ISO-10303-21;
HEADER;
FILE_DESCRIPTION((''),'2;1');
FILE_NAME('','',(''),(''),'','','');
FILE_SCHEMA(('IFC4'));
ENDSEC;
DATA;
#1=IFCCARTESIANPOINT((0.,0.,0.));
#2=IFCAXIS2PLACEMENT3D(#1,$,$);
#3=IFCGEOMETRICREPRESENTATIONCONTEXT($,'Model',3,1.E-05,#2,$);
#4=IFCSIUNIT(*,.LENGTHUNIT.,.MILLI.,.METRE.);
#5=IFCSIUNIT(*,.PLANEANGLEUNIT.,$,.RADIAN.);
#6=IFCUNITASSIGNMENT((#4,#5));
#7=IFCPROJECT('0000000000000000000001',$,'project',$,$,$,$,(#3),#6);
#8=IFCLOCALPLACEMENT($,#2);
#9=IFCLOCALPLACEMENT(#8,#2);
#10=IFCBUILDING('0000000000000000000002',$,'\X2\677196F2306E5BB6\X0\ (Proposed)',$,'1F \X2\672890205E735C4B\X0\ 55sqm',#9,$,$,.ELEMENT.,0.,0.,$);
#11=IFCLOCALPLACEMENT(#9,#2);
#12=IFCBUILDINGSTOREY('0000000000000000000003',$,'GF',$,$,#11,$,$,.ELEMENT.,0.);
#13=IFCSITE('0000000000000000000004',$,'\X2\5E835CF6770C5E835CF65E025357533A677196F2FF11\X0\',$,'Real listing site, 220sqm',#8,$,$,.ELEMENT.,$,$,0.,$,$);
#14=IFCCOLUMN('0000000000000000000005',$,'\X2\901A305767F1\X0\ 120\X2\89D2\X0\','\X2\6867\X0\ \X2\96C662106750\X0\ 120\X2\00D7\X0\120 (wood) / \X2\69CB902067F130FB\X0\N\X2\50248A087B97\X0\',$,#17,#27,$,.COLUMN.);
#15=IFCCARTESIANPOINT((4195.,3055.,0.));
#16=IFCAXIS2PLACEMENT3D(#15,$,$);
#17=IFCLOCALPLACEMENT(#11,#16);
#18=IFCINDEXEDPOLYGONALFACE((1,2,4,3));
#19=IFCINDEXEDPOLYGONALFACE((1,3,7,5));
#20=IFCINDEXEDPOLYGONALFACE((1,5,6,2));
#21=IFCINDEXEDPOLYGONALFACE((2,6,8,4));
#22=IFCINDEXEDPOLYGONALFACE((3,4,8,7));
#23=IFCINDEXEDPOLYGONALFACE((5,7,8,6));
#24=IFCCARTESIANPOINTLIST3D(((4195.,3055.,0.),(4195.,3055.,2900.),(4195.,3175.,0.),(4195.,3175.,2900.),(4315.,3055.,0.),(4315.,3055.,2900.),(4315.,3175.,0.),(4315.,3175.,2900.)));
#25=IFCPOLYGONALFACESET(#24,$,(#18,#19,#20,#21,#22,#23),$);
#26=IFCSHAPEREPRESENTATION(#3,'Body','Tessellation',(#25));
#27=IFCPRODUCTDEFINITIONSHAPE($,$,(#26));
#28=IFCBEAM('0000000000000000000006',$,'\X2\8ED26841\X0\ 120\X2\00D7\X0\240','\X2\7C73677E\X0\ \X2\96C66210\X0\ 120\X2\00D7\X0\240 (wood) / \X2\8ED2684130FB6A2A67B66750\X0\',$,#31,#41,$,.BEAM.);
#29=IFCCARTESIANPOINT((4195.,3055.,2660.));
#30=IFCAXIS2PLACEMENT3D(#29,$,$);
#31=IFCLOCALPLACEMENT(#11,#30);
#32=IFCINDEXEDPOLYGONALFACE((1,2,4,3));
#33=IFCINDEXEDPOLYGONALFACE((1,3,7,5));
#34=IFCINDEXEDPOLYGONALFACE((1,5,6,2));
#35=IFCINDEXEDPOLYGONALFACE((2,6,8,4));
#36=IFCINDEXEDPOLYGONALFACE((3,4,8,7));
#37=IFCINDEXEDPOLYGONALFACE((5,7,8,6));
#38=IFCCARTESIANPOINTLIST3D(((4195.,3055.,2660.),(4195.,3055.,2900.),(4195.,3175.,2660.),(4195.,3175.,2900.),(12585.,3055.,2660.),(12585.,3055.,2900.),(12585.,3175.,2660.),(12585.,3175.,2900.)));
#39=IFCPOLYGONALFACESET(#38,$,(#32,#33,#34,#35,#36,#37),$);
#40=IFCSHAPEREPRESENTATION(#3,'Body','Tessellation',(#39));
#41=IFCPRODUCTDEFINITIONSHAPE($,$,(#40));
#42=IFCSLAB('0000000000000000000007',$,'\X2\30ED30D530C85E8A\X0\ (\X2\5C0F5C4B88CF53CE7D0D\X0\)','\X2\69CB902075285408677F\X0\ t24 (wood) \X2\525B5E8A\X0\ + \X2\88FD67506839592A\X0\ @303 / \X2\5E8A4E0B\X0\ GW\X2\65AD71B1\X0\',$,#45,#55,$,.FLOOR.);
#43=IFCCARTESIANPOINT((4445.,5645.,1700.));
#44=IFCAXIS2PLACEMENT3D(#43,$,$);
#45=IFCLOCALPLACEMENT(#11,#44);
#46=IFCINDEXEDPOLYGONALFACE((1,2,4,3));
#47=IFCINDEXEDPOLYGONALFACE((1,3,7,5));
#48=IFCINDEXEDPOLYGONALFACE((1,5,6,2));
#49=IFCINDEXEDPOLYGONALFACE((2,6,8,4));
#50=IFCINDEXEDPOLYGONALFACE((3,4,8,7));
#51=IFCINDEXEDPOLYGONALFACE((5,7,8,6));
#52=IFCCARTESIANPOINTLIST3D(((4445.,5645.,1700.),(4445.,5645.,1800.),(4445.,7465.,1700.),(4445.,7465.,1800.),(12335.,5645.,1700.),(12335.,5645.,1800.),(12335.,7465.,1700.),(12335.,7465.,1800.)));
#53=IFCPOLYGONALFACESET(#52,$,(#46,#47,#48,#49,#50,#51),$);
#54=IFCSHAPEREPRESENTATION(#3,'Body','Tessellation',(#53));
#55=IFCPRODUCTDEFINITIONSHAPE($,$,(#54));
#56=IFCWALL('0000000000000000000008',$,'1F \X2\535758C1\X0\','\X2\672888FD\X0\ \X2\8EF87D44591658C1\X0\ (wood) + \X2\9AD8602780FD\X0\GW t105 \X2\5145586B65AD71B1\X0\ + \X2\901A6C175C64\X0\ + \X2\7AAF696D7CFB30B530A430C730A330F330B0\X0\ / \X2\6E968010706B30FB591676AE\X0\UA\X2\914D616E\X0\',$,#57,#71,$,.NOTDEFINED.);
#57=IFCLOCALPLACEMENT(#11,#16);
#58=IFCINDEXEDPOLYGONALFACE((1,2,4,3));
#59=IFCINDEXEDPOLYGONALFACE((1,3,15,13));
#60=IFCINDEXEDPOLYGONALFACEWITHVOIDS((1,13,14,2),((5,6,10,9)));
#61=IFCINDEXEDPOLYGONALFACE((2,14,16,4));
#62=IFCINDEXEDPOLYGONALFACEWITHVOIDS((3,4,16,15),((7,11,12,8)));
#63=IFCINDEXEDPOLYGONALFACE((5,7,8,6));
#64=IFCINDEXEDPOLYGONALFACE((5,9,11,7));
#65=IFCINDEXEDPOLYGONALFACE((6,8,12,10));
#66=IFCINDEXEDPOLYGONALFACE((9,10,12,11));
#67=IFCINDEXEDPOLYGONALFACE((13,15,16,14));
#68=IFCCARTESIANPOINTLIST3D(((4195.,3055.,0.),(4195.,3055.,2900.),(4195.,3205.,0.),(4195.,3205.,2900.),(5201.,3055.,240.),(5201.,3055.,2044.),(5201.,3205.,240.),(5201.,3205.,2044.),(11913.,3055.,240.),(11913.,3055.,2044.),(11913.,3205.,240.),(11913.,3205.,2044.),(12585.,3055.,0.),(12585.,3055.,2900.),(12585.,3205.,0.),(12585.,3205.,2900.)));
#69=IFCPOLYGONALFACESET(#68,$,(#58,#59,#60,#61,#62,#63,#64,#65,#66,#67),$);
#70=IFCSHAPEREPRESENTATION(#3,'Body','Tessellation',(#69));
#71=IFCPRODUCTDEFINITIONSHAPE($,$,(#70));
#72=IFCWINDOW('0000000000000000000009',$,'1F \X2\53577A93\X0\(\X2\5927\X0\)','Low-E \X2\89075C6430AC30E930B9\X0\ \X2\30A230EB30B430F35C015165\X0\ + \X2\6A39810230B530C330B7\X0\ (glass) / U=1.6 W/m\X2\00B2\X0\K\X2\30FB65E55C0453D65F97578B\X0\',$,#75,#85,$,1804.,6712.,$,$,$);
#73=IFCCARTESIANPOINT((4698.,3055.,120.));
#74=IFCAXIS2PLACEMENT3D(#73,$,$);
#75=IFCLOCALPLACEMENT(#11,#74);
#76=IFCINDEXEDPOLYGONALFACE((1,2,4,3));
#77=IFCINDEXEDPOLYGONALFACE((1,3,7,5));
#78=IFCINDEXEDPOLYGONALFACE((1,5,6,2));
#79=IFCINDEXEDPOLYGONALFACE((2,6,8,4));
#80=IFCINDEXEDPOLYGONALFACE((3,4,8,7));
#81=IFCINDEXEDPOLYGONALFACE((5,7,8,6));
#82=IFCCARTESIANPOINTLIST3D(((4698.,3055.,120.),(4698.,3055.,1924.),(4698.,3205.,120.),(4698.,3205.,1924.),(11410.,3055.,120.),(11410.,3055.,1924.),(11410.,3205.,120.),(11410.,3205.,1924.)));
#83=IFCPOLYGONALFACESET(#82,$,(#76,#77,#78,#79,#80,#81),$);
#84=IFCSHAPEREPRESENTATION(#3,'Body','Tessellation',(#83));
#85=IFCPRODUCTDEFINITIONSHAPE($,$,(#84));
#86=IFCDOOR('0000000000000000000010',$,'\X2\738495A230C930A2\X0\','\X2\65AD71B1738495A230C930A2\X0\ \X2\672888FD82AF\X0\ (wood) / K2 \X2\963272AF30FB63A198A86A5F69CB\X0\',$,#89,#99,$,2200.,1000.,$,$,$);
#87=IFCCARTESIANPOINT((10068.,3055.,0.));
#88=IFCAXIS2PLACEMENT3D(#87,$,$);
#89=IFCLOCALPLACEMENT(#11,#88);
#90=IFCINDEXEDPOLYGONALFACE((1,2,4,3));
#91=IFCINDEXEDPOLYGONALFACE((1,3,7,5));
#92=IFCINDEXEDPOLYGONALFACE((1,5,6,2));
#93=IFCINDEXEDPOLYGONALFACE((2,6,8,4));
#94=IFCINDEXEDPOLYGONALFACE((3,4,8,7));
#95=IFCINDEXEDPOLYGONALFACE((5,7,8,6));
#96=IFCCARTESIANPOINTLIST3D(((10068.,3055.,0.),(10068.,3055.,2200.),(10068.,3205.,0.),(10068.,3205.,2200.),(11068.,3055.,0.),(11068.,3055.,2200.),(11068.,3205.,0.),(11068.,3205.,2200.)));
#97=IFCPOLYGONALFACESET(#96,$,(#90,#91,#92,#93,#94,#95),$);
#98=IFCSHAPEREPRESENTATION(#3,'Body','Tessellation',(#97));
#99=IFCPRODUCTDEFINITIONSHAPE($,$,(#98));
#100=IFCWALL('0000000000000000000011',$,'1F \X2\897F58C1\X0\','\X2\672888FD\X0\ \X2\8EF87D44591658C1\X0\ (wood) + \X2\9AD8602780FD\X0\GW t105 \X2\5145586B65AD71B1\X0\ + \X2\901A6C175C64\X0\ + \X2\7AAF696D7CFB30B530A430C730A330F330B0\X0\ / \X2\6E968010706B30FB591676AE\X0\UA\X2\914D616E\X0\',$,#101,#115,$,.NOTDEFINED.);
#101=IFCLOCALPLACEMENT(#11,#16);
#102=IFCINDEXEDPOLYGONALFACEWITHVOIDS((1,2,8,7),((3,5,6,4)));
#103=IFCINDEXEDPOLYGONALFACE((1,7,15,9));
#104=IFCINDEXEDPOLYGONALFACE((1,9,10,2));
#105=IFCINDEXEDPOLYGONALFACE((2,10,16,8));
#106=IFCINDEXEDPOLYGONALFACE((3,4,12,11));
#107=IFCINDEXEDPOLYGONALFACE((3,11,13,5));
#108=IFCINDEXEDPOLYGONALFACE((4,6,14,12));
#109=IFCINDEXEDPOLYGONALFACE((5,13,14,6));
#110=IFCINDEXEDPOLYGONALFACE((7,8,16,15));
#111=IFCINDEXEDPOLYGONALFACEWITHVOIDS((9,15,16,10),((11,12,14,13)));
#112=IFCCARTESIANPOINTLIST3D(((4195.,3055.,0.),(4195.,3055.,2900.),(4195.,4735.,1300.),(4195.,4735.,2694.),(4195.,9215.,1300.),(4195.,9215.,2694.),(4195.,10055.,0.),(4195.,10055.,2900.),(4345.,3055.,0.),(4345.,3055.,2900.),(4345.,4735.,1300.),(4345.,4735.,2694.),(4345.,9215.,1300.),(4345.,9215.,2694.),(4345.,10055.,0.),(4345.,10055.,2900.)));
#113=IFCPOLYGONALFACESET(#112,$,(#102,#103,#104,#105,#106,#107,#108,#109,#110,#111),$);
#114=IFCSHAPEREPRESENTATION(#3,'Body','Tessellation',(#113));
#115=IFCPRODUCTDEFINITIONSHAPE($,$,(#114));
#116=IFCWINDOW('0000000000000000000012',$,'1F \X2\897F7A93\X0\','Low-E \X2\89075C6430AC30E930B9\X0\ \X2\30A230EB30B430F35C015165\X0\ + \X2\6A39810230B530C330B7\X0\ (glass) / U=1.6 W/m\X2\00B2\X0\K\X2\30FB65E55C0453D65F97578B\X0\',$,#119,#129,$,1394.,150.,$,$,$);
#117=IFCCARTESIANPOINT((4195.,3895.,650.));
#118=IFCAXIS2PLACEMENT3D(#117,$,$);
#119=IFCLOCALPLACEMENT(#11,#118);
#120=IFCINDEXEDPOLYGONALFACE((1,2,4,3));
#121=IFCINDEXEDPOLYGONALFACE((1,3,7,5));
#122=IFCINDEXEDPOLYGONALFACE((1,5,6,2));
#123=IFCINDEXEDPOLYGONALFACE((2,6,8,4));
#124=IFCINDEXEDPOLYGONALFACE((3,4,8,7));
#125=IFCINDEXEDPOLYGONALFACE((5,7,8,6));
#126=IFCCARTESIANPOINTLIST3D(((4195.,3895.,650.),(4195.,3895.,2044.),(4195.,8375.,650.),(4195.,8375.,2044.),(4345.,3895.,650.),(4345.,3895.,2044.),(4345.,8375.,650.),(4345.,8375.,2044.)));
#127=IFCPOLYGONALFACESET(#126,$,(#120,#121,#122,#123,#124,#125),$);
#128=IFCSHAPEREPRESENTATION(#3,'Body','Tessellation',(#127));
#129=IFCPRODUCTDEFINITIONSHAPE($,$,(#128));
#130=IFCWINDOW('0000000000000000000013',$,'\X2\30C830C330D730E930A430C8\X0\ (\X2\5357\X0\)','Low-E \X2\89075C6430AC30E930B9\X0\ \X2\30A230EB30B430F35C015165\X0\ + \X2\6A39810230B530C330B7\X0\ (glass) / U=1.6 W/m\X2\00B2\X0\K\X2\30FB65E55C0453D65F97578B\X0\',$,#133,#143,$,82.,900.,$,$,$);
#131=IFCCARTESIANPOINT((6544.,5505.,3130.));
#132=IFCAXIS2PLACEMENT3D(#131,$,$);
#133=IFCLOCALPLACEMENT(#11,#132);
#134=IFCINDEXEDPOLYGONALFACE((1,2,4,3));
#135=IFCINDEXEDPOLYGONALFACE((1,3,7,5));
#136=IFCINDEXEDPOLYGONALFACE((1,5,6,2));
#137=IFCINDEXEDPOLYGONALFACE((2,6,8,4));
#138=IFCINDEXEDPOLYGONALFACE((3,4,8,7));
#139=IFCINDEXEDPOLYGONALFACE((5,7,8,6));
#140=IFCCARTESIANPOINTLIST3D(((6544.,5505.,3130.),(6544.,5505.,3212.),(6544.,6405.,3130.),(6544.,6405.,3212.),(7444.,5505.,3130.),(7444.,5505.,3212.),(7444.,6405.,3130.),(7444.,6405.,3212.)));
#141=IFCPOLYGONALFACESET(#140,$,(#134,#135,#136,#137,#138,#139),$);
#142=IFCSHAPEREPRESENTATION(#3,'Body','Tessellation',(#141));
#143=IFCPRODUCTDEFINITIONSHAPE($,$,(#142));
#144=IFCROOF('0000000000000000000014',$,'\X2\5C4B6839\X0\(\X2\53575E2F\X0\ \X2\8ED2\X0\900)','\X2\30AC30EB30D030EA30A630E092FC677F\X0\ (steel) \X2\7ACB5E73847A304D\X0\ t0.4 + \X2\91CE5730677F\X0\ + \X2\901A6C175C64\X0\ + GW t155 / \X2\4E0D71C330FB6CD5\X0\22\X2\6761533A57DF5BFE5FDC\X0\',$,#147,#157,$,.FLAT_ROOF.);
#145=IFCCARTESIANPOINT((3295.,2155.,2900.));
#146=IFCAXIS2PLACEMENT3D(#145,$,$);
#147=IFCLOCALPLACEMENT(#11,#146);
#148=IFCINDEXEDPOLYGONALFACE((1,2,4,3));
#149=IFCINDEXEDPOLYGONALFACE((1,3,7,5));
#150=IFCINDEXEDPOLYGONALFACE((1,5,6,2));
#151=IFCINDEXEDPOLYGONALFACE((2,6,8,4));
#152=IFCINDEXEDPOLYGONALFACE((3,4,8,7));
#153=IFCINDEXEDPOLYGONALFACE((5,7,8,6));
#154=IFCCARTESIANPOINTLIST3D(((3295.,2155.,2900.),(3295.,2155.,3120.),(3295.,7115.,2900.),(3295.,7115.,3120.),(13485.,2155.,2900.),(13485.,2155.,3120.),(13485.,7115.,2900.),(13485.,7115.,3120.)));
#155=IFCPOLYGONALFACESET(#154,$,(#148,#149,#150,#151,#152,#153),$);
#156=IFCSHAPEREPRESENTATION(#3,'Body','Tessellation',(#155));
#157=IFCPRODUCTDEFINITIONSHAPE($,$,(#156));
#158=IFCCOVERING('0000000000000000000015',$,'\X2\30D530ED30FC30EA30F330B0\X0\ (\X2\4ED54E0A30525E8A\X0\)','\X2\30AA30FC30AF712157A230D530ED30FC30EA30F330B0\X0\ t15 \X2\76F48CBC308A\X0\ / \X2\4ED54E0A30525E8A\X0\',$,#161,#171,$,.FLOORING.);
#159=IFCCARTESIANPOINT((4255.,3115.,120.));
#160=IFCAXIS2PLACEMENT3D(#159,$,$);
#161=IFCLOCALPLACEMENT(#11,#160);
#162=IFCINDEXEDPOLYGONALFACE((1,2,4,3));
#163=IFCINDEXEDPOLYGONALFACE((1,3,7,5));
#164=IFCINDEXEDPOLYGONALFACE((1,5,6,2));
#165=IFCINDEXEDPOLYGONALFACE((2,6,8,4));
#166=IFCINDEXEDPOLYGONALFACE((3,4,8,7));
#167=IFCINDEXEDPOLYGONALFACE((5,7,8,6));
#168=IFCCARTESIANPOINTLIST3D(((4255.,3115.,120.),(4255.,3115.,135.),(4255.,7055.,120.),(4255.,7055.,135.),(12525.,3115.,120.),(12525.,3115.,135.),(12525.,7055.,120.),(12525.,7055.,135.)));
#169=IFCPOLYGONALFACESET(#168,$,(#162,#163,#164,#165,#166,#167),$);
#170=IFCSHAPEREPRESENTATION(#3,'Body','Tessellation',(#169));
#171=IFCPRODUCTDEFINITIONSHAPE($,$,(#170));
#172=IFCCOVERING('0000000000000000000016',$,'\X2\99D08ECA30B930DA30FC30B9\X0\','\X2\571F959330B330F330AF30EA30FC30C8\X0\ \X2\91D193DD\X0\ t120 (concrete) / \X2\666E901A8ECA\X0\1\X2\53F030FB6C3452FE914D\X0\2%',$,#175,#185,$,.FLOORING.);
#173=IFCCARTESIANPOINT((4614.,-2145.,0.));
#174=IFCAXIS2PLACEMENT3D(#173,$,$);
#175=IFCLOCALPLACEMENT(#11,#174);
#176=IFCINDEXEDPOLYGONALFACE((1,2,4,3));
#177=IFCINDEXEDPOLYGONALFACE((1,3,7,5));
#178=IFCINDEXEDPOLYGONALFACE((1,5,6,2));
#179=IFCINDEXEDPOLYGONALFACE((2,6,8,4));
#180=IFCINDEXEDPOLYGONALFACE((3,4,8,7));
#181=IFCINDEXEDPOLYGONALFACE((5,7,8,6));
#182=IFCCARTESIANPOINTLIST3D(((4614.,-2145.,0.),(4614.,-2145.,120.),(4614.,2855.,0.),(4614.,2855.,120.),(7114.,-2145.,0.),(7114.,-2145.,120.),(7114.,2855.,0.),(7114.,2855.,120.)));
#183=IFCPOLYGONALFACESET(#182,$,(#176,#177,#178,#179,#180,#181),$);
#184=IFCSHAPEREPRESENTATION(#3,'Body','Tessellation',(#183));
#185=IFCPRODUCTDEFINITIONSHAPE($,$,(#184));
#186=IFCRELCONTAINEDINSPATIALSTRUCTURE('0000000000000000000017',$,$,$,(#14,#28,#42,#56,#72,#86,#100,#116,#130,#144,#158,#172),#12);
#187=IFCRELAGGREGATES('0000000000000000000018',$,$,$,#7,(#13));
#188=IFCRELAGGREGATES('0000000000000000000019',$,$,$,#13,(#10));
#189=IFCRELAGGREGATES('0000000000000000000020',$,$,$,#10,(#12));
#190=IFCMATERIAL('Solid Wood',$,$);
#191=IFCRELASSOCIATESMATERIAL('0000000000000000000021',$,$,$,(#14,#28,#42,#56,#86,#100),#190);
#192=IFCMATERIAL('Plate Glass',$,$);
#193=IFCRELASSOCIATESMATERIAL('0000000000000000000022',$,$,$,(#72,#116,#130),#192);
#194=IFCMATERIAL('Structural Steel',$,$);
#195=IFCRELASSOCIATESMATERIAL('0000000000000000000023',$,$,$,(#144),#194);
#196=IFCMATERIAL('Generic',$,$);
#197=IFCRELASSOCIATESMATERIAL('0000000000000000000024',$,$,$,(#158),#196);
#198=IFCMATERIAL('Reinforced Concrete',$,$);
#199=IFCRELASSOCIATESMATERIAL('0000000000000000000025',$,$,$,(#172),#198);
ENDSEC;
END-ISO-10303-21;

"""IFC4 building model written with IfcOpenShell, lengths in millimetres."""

from ifc_helpers import new_model, si_unit, frame, frame_2d, origin, place, context, project, spatial, rectangle, extrude, material, element, fill, save


model = new_model("IFC4")

# Units and contexts
model_context = context("Model", 3, precision=1e-05, world=origin())
ifc_project = project(units=[si_unit("LENGTHUNIT", "METRE", prefix="MILLI"), si_unit("PLANEANGLEUNIT", "RADIAN")], contexts=[model_context])

# Site, building, storey
site_placement = place(None, origin())
site = spatial("IfcSite", under=ifc_project, at=site_placement, Name="広島県広島市南区東雲１", ObjectType="Real listing site, 220sqm", CompositionType="ELEMENT", RefElevation=0.0)
building_placement = place(site_placement, origin())
building = spatial("IfcBuilding", under=site, at=building_placement, Name="東雲の家 (Proposed)", ObjectType="1F 木造平屋 55sqm", CompositionType="ELEMENT", ElevationOfRefHeight=0.0, ElevationOfTerrain=0.0)
storey_placement = place(building_placement, origin())
storey = spatial("IfcBuildingStorey", under=building, at=storey_placement, Name="GF", CompositionType="ELEMENT", Elevation=0.0)

# Column
ifc_material_1 = material(Name="Solid Wood")
column_1_placement = place(storey_placement, frame((4195.0, 3055.0, 0.0)))
element("IfcColumn", 1, at=column_1_placement, inside=storey, material=ifc_material_1, Name="通し柱 120角", Description="桧 集成材 120×120 (wood) / 構造柱・N値計算", PredefinedType="COLUMN", context=model_context, shape_type="SweptSolid", body=[
    extrude(rectangle(XDim=120.0, YDim=120.0, at=frame_2d((60.0, 60.0))), frame((4195.0, 3055.0, 0.0)), (0.0, 0.0, 1.0), 2900.0),
])

# Beam
beam_1_placement = place(storey_placement, frame((4195.0, 3055.0, 2660.0)))
element("IfcBeam", 2, at=beam_1_placement, inside=storey, material=ifc_material_1, Name="軒桁 120×240", Description="米松 集成 120×240 (wood) / 軒桁・横架材", PredefinedType="BEAM", context=model_context, shape_type="SweptSolid", body=[
    extrude(rectangle(XDim=8390.0, YDim=120.0, at=frame_2d((4195.0, 60.0))), frame((4195.0, 3055.0, 2660.0)), (0.0, 0.0, 1.0), 240.0),
])

# Slab
ifc_material_2 = material(Name="Reinforced Concrete")
slab_1_placement = place(storey_placement, frame((4445.0, 5645.0, 1700.0)))
element("IfcSlab", 3, at=slab_1_placement, inside=storey, material=ifc_material_1, Name="ロフト床 (小屋裏収納)", Description="構造用合板 t24 (wood) 剛床 + 製材根太 @303 / 床下 GW断熱", PredefinedType="FLOOR", context=model_context, shape_type="SweptSolid", body=[
    extrude(rectangle(XDim=7890.0, YDim=1820.0, at=frame_2d((3945.0, 910.0))), frame((4445.0, 5645.0, 1700.0)), (0.0, 0.0, 1.0), 100.0),
])

# Wall, openings, window, door
wall_1_placement = place(storey_placement, frame((4195.0, 3055.0, 0.0)))
wall_1 = element("IfcWall", 4, at=wall_1_placement, inside=storey, material=ifc_material_1, Name="1F 南壁", Description="木製 軸組外壁 (wood) + 高性能GW t105 充填断熱 + 通気層 + 窯業系サイディング / 準耐火・外皮UA配慮", PredefinedType="NOTDEFINED", context=model_context, shape_type="SweptSolid", body=[
    extrude(rectangle(XDim=8390.0, YDim=150.0, at=frame_2d((4195.0, 75.0))), frame((4195.0, 3055.0, 0.0)), (0.0, 0.0, 1.0), 2900.0),
])
opening_1_placement = place(storey_placement, frame((4698.0, 3055.0, 120.0)))
opening_1 = element("IfcOpeningElement", 5, at=opening_1_placement, cuts=wall_1, PredefinedType="NOTDEFINED", context=model_context, shape_type="SweptSolid", body=[
    extrude(rectangle(XDim=6712.0, YDim=150.0, at=frame_2d((3356.0, 75.0))), frame((4698.0, 3055.0, 120.0)), (0.0, 0.0, 1.0), 1804.0),
])
opening_2_placement = place(storey_placement, frame((10068.0, 3055.0, 0.0)))
opening_2 = element("IfcOpeningElement", 6, at=opening_2_placement, cuts=wall_1, PredefinedType="NOTDEFINED", context=model_context, shape_type="SweptSolid", body=[
    extrude(rectangle(XDim=1000.0, YDim=150.0, at=frame_2d((500.0, 75.0))), frame((10068.0, 3055.0, 0.0)), (0.0, 0.0, 1.0), 2200.0),
])
ifc_material_3 = material(Name="Plate Glass")
window_1_placement = place(storey_placement, frame((4698.0, 3055.0, 120.0)))
window_1 = element("IfcWindow", 7, at=window_1_placement, inside=storey, material=ifc_material_3, Name="1F 南窓(大)", Description="Low-E 複層ガラス アルゴン封入 + 樹脂サッシ (glass) / U=1.6 W/m²K・日射取得型", OverallHeight=1804.0, OverallWidth=6712.0, context=model_context, shape_type="SweptSolid", body=[
    extrude(rectangle(XDim=6712.0, YDim=150.0, at=frame_2d((3356.0, 75.0))), frame((4698.0, 3055.0, 120.0)), (0.0, 0.0, 1.0), 1804.0),
])
fill(opening_1, window_1)
door_1_placement = place(storey_placement, frame((10068.0, 3055.0, 0.0)))
door_1 = element("IfcDoor", 8, at=door_1_placement, inside=storey, material=ifc_material_1, Name="玄関ドア", Description="断熱玄関ドア 木製芯 (wood) / K2 防犯・採風機構", OverallHeight=2200.0, OverallWidth=1000.0, context=model_context, shape_type="SweptSolid", body=[
    extrude(rectangle(XDim=1000.0, YDim=150.0, at=frame_2d((500.0, 75.0))), frame((10068.0, 3055.0, 0.0)), (0.0, 0.0, 1.0), 2200.0),
])
fill(opening_2, door_1)

# Wall, opening, window
wall_2_placement = place(storey_placement, frame((4195.0, 3055.0, 0.0)))
wall_2 = element("IfcWall", 9, at=wall_2_placement, inside=storey, material=ifc_material_1, Name="1F 西壁", Description="木製 軸組外壁 (wood) + 高性能GW t105 充填断熱 + 通気層 + 窯業系サイディング / 準耐火・外皮UA配慮", PredefinedType="NOTDEFINED", context=model_context, shape_type="SweptSolid", body=[
    extrude(rectangle(XDim=150.0, YDim=7000.0, at=frame_2d((75.0, 3500.0))), frame((4195.0, 3055.0, 0.0)), (0.0, 0.0, 1.0), 2900.0),
])
opening_3_placement = place(storey_placement, frame((4195.0, 3895.0, 650.0)))
opening_3 = element("IfcOpeningElement", 10, at=opening_3_placement, cuts=wall_2, PredefinedType="NOTDEFINED", context=model_context, shape_type="SweptSolid", body=[
    extrude(rectangle(XDim=150.0, YDim=4480.0, at=frame_2d((75.0, 2240.0))), frame((4195.0, 3895.0, 650.0)), (0.0, 0.0, 1.0), 1394.0),
])
window_2_placement = place(storey_placement, frame((4195.0, 3895.0, 650.0)))
window_2 = element("IfcWindow", 11, at=window_2_placement, inside=storey, material=ifc_material_3, Name="1F 西窓", Description="Low-E 複層ガラス アルゴン封入 + 樹脂サッシ (glass) / U=1.6 W/m²K・日射取得型", OverallHeight=1394.0, OverallWidth=150.0, context=model_context, shape_type="SweptSolid", body=[
    extrude(rectangle(XDim=150.0, YDim=4480.0, at=frame_2d((75.0, 2240.0))), frame((4195.0, 3895.0, 650.0)), (0.0, 0.0, 1.0), 1394.0),
])
fill(opening_3, window_2)

# Window
window_3_placement = place(storey_placement, frame((6544.0, 5505.0, 3130.0)))
element("IfcWindow", 12, at=window_3_placement, inside=storey, material=ifc_material_3, Name="トップライト (南)", Description="Low-E 複層ガラス アルゴン封入 + 樹脂サッシ (glass) / U=1.6 W/m²K・日射取得型", OverallHeight=82.0, OverallWidth=900.0, context=model_context, shape_type="SweptSolid", body=[
    extrude(rectangle(XDim=900.0, YDim=900.0, at=frame_2d((450.0, 450.0))), frame((6544.0, 5505.0, 3130.0)), (0.0, 0.0, 1.0), 82.0),
])

# Roof
ifc_material_4 = material(Name="Structural Steel")
roof_placement = place(storey_placement, frame((3295.0, 2155.0, 2900.0)))
element("IfcRoof", 13, at=roof_placement, inside=storey, material=ifc_material_4, Name="屋根(南帯 軒900)", Description="ガルバリウム鋼板 (steel) 立平葺き t0.4 + 野地板 + 通気層 + GW t155 / 不燃・法22条区域対応", PredefinedType="FLAT_ROOF", context=model_context, shape_type="SweptSolid", body=[
    extrude(rectangle(XDim=10190.0, YDim=4960.0, at=frame_2d((5095.0, 2480.0))), frame((3295.0, 2155.0, 2900.0)), (0.0, 0.0, 1.0), 220.0),
])

# Coverings
ifc_material_5 = material(Name="Generic")
covering_1_placement = place(storey_placement, frame((4255.0, 3115.0, 120.0)))
element("IfcCovering", 14, at=covering_1_placement, inside=storey, material=ifc_material_5, Name="フローリング (仕上げ床)", Description="オーク無垢フローリング t15 直貼り / 仕上げ床", PredefinedType="FLOORING", context=model_context, shape_type="SweptSolid", body=[
    extrude(rectangle(XDim=8270.0, YDim=3940.0, at=frame_2d((4135.0, 1970.0))), frame((4255.0, 3115.0, 120.0)), (0.0, 0.0, 1.0), 15.0),
])
covering_2_placement = place(storey_placement, frame((4614.0, -2145.0, 0.0)))
element("IfcCovering", 15, at=covering_2_placement, inside=storey, material=ifc_material_2, Name="駐車スペース", Description="土間コンクリート 金鏝 t120 (concrete) / 普通車1台・水勾配2%", PredefinedType="FLOORING", context=model_context, shape_type="SweptSolid", body=[
    extrude(rectangle(XDim=2500.0, YDim=5000.0, at=frame_2d((1250.0, 2500.0))), frame((4614.0, -2145.0, 0.0)), (0.0, 0.0, 1.0), 120.0),
])

save(model, "model.ifc")
